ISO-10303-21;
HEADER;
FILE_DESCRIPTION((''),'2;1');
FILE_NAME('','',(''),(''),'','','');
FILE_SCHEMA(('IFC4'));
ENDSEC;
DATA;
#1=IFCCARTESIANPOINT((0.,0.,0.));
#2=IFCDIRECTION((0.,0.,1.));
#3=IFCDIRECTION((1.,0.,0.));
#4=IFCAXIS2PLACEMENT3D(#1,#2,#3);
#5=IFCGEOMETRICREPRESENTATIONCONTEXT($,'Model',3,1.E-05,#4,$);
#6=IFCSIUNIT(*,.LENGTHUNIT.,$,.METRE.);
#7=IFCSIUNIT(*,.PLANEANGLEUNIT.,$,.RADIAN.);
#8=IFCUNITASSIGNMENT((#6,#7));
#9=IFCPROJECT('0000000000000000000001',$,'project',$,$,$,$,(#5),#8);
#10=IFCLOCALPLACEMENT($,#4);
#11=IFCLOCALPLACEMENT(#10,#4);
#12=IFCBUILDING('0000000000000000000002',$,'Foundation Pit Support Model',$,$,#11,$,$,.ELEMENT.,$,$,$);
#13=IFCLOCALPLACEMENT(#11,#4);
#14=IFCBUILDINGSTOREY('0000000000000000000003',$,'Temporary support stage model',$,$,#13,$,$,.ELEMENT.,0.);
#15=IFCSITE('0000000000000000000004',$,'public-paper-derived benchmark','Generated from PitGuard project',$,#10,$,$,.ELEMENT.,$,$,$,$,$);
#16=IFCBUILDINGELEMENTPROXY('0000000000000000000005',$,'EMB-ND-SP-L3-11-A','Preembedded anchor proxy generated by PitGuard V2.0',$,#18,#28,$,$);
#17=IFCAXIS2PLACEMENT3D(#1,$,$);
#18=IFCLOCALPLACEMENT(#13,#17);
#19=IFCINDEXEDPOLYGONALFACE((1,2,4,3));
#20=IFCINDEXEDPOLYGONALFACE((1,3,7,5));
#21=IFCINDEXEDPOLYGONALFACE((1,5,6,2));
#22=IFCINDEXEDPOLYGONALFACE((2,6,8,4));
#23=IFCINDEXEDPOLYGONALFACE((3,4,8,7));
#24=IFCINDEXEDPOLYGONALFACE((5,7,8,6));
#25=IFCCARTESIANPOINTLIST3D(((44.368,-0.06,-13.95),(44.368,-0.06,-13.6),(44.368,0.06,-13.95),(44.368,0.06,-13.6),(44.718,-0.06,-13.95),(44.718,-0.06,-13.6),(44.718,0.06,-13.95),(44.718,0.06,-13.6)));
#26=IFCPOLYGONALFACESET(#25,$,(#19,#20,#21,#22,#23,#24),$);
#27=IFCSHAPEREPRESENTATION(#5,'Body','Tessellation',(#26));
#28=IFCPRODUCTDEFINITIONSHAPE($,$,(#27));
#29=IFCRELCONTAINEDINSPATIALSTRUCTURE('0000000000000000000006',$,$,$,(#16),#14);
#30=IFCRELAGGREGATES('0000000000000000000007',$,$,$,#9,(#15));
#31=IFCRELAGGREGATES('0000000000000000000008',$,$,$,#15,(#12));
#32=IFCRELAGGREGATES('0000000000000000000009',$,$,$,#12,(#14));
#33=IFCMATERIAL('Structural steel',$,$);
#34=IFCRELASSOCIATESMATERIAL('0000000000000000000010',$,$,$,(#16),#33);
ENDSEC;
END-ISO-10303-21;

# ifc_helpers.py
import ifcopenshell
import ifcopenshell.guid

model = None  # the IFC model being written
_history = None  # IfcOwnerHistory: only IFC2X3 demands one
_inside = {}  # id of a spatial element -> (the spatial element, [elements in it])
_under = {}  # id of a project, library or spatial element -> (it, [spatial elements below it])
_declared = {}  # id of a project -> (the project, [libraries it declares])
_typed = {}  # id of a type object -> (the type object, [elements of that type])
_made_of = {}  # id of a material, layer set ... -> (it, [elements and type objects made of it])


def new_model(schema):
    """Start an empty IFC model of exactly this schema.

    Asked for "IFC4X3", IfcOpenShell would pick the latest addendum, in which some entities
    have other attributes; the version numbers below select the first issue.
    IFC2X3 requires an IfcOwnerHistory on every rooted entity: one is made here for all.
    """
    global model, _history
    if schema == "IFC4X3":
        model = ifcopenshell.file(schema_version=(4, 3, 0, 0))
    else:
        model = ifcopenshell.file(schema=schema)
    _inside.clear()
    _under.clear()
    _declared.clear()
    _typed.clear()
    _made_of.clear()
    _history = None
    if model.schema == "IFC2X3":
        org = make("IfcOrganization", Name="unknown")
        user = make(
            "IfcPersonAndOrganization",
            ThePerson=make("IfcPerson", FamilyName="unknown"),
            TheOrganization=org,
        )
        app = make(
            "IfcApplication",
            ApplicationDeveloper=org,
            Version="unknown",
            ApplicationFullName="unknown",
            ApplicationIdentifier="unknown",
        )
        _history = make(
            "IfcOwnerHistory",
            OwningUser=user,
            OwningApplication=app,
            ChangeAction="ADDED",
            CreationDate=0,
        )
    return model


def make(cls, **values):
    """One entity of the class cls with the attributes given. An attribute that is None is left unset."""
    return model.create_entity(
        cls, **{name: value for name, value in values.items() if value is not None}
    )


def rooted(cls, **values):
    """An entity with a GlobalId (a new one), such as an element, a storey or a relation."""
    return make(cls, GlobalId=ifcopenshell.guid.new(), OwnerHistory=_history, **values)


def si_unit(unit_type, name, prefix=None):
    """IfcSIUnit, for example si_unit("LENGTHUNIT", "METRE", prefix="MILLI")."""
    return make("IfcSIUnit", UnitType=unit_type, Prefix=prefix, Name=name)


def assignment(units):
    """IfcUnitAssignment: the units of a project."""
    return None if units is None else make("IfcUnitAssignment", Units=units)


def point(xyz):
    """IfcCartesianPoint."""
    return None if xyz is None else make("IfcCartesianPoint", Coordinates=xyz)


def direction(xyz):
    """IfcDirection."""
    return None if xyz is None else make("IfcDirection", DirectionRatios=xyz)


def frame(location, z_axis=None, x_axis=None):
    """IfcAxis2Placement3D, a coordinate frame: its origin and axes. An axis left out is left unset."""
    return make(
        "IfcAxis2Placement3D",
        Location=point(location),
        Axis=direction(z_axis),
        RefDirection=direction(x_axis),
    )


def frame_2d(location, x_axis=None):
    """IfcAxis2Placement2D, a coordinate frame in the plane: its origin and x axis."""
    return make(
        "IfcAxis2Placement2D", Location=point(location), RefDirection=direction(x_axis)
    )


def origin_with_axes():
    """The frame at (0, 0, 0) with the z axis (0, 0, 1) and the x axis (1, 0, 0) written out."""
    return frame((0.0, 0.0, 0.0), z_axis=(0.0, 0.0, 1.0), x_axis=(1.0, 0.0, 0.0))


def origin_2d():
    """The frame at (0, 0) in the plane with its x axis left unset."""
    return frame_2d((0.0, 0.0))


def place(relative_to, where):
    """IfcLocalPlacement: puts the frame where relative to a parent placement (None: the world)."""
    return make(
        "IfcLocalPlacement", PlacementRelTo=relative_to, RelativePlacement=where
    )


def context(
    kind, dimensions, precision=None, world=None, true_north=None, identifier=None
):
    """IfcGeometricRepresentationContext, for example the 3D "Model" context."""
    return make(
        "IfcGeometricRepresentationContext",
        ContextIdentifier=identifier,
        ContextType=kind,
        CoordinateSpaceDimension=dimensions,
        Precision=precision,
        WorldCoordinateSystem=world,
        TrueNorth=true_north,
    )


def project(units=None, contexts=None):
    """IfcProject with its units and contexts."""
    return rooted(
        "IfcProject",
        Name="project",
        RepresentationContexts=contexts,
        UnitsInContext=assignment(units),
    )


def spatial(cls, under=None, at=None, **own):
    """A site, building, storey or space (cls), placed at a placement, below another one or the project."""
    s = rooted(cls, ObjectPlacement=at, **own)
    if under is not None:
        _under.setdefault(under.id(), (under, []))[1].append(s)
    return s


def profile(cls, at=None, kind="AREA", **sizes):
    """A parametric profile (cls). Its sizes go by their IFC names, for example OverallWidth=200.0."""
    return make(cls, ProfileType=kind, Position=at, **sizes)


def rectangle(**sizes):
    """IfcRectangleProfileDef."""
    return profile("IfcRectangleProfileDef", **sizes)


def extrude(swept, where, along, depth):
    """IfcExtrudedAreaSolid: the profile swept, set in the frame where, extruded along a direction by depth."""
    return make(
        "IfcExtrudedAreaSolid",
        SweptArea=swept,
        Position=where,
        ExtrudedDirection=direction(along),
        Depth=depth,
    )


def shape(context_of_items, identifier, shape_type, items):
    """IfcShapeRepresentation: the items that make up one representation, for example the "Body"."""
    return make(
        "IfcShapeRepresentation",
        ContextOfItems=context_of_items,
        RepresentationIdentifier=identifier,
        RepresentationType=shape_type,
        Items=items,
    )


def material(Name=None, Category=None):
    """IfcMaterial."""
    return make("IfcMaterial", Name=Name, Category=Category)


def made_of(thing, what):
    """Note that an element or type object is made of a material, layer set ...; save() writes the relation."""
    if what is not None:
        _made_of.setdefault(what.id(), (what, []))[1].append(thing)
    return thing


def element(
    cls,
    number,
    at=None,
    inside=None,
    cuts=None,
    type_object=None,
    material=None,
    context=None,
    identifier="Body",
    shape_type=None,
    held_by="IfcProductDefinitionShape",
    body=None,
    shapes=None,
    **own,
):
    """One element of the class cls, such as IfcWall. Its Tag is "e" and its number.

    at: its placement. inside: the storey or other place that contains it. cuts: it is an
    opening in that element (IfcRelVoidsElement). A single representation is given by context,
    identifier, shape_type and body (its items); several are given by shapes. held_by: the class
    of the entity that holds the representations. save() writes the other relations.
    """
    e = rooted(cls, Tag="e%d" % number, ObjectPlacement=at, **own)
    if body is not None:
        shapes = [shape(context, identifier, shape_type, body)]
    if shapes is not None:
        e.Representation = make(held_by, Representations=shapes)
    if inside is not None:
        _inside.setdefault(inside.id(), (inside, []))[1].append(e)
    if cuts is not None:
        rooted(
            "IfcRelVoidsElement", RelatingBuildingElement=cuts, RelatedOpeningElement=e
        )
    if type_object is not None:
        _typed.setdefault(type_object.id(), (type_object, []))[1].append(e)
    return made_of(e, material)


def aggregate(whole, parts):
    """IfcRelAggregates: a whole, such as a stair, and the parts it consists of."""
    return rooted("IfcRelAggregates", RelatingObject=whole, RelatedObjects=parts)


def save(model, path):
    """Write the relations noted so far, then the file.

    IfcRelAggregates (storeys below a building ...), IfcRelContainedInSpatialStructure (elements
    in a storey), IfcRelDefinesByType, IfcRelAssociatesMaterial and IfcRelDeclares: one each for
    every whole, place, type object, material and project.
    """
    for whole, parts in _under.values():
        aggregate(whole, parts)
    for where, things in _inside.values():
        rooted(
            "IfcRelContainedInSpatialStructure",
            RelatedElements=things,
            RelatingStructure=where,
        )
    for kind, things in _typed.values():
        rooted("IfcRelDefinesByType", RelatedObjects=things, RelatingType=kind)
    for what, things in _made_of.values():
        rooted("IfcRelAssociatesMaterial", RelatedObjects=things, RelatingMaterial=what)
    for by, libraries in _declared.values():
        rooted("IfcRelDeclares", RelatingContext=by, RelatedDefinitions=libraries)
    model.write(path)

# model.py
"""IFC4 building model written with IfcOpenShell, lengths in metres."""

from ifc_helpers import new_model, si_unit, frame, origin_with_axes, origin_2d, place, context, project, spatial, rectangle, extrude, material, element, save


model = new_model("IFC4")

# Units and contexts
model_context = context("Model", 3, precision=1e-05, world=origin_with_axes())
ifc_project = project(units=[si_unit("LENGTHUNIT", "METRE"), si_unit("PLANEANGLEUNIT", "RADIAN")], contexts=[model_context])

# Site, building, storey
site_placement = place(None, origin_with_axes())
site = spatial("IfcSite", under=ifc_project, at=site_placement, Name="public-paper-derived benchmark", Description="Generated from PitGuard project", CompositionType="ELEMENT")
building_placement = place(site_placement, origin_with_axes())
building = spatial("IfcBuilding", under=site, at=building_placement, Name="Foundation Pit Support Model", CompositionType="ELEMENT")
storey_placement = place(building_placement, origin_with_axes())
storey = spatial("IfcBuildingStorey", under=building, at=storey_placement, Name="Temporary support stage model", CompositionType="ELEMENT", Elevation=0.0)

# Shared definitions
ifc_material_1 = material(Name="Structural steel")

# Building element proxy
proxy_1_placement = place(storey_placement, frame((44.543, 0.0, -13.95), z_axis=(0.0, 0.0, 1.0), x_axis=(1.0, 0.0, 0.0)))
element("IfcBuildingElementProxy", 1, at=proxy_1_placement, inside=storey, material=ifc_material_1, Name="EMB-ND-SP-L3-11-A", Description="Preembedded anchor proxy generated by PitGuard V2.0", context=model_context, shape_type="SweptSolid", body=[
    extrude(rectangle(XDim=0.35, YDim=0.12, at=origin_2d()), origin_with_axes(), (0.0, 0.0, 1.0), 0.35),
])

save(model, "model.ifc")
